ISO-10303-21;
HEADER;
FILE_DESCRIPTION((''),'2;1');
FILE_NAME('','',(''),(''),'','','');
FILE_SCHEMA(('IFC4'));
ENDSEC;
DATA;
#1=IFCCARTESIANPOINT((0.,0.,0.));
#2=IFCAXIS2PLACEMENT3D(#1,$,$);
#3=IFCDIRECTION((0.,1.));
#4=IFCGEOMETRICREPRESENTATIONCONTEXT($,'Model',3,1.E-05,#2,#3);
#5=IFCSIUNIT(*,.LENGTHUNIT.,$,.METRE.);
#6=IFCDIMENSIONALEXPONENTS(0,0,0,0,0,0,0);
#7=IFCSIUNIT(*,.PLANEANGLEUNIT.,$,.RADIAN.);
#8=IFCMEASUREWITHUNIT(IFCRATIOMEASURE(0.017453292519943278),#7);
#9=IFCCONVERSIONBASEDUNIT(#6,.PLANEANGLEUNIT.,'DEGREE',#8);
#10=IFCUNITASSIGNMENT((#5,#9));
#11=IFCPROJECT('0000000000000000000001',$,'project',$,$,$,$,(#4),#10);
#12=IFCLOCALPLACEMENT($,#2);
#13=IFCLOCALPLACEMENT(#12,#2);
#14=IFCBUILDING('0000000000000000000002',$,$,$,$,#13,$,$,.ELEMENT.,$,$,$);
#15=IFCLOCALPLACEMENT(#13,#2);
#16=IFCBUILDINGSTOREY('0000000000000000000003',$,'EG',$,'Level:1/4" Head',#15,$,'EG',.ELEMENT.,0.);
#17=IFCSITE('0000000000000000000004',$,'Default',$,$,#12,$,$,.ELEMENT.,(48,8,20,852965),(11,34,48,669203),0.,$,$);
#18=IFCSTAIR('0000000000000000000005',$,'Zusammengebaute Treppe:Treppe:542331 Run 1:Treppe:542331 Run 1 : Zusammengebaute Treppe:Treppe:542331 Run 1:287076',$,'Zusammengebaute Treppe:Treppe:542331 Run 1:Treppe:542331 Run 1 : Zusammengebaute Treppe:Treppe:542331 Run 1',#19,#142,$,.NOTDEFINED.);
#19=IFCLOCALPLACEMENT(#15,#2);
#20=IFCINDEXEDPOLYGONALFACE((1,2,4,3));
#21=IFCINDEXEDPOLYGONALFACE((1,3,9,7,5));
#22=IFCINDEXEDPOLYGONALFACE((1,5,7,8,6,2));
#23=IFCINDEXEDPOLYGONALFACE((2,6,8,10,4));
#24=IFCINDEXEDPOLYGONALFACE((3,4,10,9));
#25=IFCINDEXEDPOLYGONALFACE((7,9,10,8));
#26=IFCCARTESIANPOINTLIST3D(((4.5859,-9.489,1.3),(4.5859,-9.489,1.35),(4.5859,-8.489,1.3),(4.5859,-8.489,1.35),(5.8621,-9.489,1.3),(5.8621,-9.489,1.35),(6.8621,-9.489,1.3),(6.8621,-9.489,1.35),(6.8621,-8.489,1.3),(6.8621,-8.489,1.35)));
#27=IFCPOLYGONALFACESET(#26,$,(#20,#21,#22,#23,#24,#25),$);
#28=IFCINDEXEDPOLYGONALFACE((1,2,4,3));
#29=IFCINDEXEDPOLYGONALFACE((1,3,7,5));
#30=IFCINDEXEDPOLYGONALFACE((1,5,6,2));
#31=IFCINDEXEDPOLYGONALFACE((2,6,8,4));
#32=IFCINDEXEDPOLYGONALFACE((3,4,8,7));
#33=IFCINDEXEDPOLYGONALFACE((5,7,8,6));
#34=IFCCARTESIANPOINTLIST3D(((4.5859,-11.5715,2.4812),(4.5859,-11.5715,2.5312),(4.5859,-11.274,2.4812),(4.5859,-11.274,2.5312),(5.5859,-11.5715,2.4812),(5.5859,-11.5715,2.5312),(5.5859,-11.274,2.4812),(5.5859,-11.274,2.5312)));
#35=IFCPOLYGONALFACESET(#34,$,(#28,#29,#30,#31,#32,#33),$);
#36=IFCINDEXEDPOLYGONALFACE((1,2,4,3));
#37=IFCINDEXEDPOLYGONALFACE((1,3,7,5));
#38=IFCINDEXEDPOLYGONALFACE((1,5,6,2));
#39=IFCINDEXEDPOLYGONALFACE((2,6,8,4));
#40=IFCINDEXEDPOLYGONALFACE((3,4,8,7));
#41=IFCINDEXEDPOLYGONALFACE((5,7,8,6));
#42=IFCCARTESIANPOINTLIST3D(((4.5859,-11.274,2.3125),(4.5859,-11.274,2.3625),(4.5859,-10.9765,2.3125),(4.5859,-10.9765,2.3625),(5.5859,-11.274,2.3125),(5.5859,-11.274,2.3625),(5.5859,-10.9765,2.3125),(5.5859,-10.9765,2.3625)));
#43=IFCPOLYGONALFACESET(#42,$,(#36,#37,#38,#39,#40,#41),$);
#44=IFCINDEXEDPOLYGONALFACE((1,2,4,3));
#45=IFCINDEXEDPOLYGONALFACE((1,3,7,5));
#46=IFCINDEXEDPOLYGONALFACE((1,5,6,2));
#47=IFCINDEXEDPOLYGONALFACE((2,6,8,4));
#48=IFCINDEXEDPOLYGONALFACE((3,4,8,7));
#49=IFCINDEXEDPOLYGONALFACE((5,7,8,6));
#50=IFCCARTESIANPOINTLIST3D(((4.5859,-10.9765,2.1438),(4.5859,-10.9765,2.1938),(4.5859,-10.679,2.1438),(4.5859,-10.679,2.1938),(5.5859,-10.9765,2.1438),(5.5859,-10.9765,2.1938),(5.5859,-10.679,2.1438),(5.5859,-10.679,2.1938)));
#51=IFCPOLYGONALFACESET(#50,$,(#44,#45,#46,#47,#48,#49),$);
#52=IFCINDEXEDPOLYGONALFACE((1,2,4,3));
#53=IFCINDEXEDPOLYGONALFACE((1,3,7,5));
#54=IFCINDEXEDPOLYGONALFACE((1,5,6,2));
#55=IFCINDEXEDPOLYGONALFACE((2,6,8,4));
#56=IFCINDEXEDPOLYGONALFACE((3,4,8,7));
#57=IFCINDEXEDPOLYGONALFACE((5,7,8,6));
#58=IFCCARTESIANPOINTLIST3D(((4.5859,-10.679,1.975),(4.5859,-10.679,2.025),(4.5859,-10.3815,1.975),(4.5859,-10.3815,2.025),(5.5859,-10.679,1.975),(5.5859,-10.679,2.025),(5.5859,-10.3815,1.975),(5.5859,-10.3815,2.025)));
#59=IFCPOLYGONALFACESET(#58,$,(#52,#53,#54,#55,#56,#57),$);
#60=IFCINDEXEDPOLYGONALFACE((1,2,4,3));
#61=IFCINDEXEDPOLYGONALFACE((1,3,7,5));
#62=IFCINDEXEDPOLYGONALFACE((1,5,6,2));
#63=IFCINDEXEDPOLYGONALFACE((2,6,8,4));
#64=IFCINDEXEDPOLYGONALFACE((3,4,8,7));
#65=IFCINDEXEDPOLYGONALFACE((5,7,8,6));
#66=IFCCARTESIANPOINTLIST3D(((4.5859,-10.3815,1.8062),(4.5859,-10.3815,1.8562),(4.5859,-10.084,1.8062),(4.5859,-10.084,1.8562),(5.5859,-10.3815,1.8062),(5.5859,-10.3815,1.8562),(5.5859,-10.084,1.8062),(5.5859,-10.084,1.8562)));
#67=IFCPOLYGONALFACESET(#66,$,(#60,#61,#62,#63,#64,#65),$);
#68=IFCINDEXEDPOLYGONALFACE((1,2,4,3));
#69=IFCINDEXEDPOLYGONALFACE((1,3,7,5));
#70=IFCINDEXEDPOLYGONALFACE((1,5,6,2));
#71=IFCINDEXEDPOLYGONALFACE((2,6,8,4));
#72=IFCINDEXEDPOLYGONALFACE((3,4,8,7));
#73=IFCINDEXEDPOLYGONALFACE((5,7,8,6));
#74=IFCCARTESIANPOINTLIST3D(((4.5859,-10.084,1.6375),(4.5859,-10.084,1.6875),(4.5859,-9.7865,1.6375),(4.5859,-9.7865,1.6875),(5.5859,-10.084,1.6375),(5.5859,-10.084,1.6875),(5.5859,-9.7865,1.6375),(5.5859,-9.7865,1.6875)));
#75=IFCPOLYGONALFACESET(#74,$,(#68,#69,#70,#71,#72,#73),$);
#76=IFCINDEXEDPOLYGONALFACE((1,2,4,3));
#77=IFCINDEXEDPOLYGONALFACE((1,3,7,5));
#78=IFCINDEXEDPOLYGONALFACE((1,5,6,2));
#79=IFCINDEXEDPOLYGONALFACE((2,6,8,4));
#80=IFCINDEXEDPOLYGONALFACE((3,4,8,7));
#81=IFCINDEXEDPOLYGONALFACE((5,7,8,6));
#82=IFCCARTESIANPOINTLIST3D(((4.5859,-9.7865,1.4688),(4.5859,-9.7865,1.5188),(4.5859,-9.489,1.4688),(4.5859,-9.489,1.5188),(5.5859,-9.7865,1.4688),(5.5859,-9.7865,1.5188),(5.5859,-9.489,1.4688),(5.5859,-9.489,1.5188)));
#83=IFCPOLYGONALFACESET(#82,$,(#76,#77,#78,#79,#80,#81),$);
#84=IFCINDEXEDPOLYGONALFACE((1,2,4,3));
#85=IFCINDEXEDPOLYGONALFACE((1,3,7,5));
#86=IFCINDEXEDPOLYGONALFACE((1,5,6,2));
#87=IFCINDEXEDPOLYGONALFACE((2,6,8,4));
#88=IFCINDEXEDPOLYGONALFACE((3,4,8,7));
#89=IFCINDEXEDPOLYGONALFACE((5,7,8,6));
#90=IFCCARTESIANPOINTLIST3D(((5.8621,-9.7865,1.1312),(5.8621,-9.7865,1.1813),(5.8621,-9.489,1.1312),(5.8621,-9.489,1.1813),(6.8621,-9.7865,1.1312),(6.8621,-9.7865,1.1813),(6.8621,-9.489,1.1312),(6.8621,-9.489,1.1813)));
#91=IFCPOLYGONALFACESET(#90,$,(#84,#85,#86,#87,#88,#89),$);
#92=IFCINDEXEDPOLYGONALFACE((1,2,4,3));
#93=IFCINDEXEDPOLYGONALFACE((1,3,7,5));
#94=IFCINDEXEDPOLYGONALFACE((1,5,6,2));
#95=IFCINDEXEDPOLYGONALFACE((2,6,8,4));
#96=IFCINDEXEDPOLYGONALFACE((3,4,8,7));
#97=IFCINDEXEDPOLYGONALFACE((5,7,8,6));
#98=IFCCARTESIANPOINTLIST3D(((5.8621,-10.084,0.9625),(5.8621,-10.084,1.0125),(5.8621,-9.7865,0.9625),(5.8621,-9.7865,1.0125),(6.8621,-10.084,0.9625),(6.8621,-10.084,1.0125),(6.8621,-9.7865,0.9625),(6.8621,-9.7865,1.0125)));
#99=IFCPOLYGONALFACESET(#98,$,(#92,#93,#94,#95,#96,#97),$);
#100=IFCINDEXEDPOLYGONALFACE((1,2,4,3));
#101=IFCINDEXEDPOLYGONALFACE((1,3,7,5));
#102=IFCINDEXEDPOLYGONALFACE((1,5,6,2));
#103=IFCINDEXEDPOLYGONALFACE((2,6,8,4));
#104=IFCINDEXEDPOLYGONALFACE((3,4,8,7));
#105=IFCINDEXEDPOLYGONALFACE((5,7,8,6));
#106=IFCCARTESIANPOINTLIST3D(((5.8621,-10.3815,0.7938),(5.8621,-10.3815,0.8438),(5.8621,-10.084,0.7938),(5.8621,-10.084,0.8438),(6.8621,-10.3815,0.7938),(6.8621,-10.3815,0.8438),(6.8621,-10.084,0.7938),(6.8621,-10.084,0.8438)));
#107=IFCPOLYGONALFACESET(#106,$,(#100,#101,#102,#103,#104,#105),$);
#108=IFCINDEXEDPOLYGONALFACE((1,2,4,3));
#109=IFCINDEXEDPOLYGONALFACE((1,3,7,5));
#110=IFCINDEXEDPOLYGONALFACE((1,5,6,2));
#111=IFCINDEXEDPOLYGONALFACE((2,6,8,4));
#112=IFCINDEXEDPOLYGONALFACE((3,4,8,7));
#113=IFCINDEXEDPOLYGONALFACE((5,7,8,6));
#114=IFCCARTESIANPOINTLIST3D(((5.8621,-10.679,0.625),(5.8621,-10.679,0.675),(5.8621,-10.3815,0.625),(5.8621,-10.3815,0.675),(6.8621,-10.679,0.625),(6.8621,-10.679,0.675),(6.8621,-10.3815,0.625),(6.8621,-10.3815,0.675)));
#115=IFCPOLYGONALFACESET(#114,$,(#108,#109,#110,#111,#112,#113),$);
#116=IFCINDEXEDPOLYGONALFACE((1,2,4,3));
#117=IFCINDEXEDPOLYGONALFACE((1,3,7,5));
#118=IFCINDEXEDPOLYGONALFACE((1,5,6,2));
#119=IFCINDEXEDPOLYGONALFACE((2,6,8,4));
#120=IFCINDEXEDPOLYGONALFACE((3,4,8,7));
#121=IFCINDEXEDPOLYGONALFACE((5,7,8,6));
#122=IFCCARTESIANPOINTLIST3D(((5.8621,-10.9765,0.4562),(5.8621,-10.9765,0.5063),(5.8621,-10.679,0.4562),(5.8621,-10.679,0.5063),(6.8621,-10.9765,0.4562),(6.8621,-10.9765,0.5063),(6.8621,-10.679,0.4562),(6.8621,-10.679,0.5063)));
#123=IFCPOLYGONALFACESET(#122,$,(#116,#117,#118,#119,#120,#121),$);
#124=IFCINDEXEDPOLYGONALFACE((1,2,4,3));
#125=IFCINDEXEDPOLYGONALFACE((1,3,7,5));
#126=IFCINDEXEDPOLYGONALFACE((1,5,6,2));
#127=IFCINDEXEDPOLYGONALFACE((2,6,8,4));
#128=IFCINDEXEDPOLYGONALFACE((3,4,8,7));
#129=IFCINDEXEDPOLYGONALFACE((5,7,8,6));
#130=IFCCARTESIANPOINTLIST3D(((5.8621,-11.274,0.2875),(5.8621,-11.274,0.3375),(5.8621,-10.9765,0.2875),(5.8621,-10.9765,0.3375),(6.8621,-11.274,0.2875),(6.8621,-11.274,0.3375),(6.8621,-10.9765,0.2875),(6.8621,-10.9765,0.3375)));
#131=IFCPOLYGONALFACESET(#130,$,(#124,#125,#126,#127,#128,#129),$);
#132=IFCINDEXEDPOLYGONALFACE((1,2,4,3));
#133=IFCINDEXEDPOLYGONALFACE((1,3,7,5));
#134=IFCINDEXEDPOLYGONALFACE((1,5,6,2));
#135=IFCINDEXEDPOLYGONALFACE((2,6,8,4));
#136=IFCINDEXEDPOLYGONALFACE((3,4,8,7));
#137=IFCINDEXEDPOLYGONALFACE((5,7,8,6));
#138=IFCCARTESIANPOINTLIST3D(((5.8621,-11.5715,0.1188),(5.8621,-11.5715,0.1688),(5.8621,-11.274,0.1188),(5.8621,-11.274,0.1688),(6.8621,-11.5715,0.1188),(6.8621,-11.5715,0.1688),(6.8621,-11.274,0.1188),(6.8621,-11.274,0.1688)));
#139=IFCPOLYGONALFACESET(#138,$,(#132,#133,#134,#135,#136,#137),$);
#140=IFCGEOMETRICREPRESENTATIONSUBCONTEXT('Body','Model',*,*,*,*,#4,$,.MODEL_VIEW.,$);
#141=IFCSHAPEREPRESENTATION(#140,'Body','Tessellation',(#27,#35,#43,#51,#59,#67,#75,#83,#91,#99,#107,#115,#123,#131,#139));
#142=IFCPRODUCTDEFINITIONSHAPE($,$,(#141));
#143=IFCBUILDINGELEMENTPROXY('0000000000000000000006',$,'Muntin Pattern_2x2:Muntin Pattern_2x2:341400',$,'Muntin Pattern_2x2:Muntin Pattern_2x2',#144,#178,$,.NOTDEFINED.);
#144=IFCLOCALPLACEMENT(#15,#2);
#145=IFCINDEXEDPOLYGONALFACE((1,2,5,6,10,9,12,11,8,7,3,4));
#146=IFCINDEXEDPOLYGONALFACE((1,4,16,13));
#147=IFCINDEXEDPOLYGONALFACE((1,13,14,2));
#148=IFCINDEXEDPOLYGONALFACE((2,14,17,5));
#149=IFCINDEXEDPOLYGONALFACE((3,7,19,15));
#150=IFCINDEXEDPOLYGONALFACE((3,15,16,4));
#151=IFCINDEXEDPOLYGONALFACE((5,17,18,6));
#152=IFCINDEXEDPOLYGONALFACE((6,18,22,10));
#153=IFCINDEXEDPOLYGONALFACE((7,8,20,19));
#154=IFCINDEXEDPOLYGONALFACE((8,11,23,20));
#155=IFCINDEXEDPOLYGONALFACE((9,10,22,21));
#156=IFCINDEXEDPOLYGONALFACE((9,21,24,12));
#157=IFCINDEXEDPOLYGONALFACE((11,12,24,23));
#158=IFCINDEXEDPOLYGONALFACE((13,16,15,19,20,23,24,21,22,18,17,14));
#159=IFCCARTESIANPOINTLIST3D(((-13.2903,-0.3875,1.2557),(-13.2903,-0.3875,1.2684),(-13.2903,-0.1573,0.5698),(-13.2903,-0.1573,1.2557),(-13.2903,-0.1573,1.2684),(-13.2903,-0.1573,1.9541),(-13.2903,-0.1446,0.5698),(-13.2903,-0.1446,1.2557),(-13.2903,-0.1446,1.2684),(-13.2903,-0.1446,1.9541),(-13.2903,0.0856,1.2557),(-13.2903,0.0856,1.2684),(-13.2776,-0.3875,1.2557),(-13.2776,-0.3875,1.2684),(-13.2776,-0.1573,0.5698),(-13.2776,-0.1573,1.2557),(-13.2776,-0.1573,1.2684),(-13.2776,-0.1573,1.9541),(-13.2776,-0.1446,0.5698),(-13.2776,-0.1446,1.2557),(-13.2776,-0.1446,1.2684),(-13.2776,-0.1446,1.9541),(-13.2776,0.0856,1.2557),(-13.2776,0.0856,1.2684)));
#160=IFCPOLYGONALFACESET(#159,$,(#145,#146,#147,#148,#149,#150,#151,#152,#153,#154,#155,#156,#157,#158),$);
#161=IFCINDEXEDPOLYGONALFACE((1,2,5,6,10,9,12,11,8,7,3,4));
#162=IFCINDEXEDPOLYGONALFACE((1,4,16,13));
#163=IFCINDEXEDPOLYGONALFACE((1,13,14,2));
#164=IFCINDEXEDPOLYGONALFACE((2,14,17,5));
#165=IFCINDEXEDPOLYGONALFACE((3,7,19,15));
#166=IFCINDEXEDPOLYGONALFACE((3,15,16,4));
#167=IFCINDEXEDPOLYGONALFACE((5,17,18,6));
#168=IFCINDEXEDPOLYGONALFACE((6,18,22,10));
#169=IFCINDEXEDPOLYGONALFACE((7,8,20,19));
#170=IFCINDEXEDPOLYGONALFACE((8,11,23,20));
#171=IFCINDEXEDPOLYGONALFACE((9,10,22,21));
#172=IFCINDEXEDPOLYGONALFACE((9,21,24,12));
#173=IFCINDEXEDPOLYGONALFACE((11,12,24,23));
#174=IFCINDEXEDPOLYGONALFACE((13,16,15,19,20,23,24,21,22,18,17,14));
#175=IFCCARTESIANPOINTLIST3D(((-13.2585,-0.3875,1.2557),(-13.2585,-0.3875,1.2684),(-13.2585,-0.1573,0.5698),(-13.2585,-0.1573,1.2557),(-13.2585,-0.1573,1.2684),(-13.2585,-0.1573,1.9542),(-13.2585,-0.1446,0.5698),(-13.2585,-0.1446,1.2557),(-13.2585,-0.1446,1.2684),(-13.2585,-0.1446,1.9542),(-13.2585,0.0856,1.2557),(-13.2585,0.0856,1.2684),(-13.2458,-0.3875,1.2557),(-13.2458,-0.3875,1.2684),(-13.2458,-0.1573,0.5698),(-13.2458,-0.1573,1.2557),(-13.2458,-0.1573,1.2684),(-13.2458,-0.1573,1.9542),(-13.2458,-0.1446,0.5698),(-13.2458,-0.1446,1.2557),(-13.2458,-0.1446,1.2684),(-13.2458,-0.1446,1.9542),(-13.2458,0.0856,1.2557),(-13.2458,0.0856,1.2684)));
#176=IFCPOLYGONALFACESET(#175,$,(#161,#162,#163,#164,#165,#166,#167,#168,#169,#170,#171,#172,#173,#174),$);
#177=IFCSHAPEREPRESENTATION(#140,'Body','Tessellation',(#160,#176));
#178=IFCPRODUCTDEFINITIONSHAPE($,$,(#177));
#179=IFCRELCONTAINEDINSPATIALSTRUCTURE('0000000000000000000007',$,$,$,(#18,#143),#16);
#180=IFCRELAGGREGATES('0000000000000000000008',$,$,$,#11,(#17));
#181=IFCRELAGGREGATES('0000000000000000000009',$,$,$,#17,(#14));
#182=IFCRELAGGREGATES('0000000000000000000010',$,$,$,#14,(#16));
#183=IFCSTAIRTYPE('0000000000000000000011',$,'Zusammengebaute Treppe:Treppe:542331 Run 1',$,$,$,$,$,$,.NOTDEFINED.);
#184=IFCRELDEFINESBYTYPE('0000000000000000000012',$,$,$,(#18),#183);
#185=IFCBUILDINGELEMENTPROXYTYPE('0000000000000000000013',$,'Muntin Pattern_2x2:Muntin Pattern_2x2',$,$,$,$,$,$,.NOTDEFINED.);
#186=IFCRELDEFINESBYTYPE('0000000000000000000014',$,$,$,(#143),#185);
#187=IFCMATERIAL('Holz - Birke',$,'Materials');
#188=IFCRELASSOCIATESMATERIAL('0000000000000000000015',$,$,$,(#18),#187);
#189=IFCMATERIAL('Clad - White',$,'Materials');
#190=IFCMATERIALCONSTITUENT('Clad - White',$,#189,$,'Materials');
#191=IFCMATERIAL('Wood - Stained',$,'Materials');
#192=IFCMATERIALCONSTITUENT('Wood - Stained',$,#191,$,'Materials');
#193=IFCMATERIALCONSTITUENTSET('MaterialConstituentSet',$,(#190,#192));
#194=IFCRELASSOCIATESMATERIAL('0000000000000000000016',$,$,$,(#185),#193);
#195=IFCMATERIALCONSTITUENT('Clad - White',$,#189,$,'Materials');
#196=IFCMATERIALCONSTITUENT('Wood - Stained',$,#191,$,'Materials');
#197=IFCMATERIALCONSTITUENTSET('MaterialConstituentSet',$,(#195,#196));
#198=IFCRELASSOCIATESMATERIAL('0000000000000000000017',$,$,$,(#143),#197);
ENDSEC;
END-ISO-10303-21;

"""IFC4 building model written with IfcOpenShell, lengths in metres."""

from ifc_helpers import new_model, entity, si_unit, converted_unit, direction, frame, origin, place, context, subcontext, project, spatial, indexed_curve, outline, extrude, source, transform, mapped, material, constituent, constituent_set, type_object, type_shapes, element, save


model = new_model("IFC4")

# Units and contexts
model_context = context("Model", 3, precision=1e-05, world=origin(), true_north=direction((0.0, 1.0)))
body_context = subcontext(model_context, "Body", "Model", "MODEL_VIEW")
ifc_project = project(units=[si_unit("LENGTHUNIT", "METRE"), converted_unit("PLANEANGLEUNIT", "DEGREE", entity("IfcRatioMeasure", 0.017453292519943278), si_unit("PLANEANGLEUNIT", "RADIAN"), dimensions=[0, 0, 0, 0, 0, 0, 0])], contexts=[model_context])

# Site, building, storey
site_placement = place(None, origin())
site = spatial("IfcSite", under=ifc_project, at=site_placement, Name="Default", CompositionType="ELEMENT", RefLatitude=(48, 8, 20, 852965), RefLongitude=(11, 34, 48, 669203), RefElevation=0.0)
building_placement = place(site_placement, origin())
building = spatial("IfcBuilding", under=site, at=building_placement, CompositionType="ELEMENT")
storey_placement = place(building_placement, origin())
storey = spatial("IfcBuildingStorey", under=building, at=storey_placement, Name="EG", ObjectType="Level:1/4\" Head", LongName="EG", CompositionType="ELEMENT", Elevation=0.0)

# Stair
ifc_material_1 = material(Name="Holz - Birke", Category="Materials")
stair_type_1 = type_object("IfcStairType", Name="Zusammengebaute Treppe:Treppe:542331 Run 1", PredefinedType="NOTDEFINED")
stair_1_placement = place(storey_placement, origin())
element("IfcStair", 1, at=stair_1_placement, inside=storey, type_object=stair_type_1, material=ifc_material_1, Name="Zusammengebaute Treppe:Treppe:542331 Run 1:Treppe:542331 Run 1 : Zusammengebaute Treppe:Treppe:542331 Run 1:287076", ObjectType="Zusammengebaute Treppe:Treppe:542331 Run 1:Treppe:542331 Run 1 : Zusammengebaute Treppe:Treppe:542331 Run 1", PredefinedType="NOTDEFINED", context=body_context, shape_type="SweptSolid", body=[
    extrude(outline(indexed_curve([(-0.4, -1.1105), (0.6, -1.1105), (0.6, 1.1657), (-0.4, 1.1657), (-0.4, -0.1105), (-0.4, -1.1105)], self_intersect=False)), frame((5.7516, -9.089, 1.3), z_axis=(0.0, 0.0, 1.0), x_axis=(0.0, 1.0, 0.0)), (0.0, 0.0, 1.0), 0.05),
    extrude(outline(indexed_curve([(-0.5, -0.1487), (0.5, -0.1487), (0.5, 0.1487), (-0.5, 0.1487), (-0.5, -0.1487)], self_intersect=False)), frame((5.0859, -11.4228, 2.4813), z_axis=(0.0, 0.0, 1.0), x_axis=(-1.0, 0.0, 0.0)), (0.0, 0.0, 1.0), 0.05),
    extrude(outline(indexed_curve([(-0.5, -0.1487), (0.5, -0.1487), (0.5, 0.1487), (-0.5, 0.1487), (-0.5, -0.1487)], self_intersect=False)), frame((5.0859, -11.1253, 2.3125), z_axis=(0.0, 0.0, 1.0), x_axis=(-1.0, 0.0, 0.0)), (0.0, 0.0, 1.0), 0.05),
    extrude(outline(indexed_curve([(-0.5, -0.1487), (0.5, -0.1487), (0.5, 0.1487), (-0.5, 0.1487), (-0.5, -0.1487)], self_intersect=False)), frame((5.0859, -10.8278, 2.1438), z_axis=(0.0, 0.0, 1.0), x_axis=(-1.0, 0.0, 0.0)), (0.0, 0.0, 1.0), 0.05),
    extrude(outline(indexed_curve([(-0.5, -0.1487), (0.5, -0.1487), (0.5, 0.1487), (-0.5, 0.1487), (-0.5, -0.1487)], self_intersect=False)), frame((5.0859, -10.5303, 1.975), z_axis=(0.0, 0.0, 1.0), x_axis=(-1.0, 0.0, 0.0)), (0.0, 0.0, 1.0), 0.05),
    extrude(outline(indexed_curve([(-0.5, -0.1487), (0.5, -0.1487), (0.5, 0.1487), (-0.5, 0.1487), (-0.5, -0.1487)], self_intersect=False)), frame((5.0859, -10.2328, 1.8063), z_axis=(0.0, 0.0, 1.0), x_axis=(-1.0, 0.0, 0.0)), (0.0, 0.0, 1.0), 0.05),
    extrude(outline(indexed_curve([(-0.5, -0.1487), (0.5, -0.1487), (0.5, 0.1488), (-0.5, 0.1488), (-0.5, -0.1487)], self_intersect=False)), frame((5.0859, -9.9353, 1.6375), z_axis=(0.0, 0.0, 1.0), x_axis=(-1.0, 0.0, 0.0)), (0.0, 0.0, 1.0), 0.05),
    extrude(outline(indexed_curve([(-0.5, -0.1487), (0.5, -0.1487), (0.5, 0.1487), (-0.5, 0.1487), (-0.5, -0.1487)], self_intersect=False)), frame((5.0859, -9.6378, 1.4688), z_axis=(0.0, 0.0, 1.0), x_axis=(-1.0, 0.0, 0.0)), (0.0, 0.0, 1.0), 0.05),
    extrude(outline(indexed_curve([(-0.5, -0.1487), (0.5, -0.1487), (0.5, 0.1487), (-0.5, 0.1487), (-0.5, -0.1487)], self_intersect=False)), frame((6.3621, -9.6378, 1.1313)), (0.0, 0.0, 1.0), 0.05),
    extrude(outline(indexed_curve([(-0.5, -0.1487), (0.5, -0.1487), (0.5, 0.1487), (-0.5, 0.1487), (-0.5, -0.1487)], self_intersect=False)), frame((6.3621, -9.9353, 0.9625)), (0.0, 0.0, 1.0), 0.05),
    extrude(outline(indexed_curve([(-0.5, -0.1487), (0.5, -0.1487), (0.5, 0.1487), (-0.5, 0.1487), (-0.5, -0.1487)], self_intersect=False)), frame((6.3621, -10.2328, 0.7938)), (0.0, 0.0, 1.0), 0.05),
    extrude(outline(indexed_curve([(-0.5, -0.1487), (0.5, -0.1487), (0.5, 0.1487), (-0.5, 0.1487), (-0.5, -0.1487)], self_intersect=False)), frame((6.3621, -10.5303, 0.625)), (0.0, 0.0, 1.0), 0.05),
    extrude(outline(indexed_curve([(-0.5, -0.1487), (0.5, -0.1487), (0.5, 0.1487), (-0.5, 0.1487), (-0.5, -0.1487)], self_intersect=False)), frame((6.3621, -10.8278, 0.4563)), (0.0, 0.0, 1.0), 0.05),
    extrude(outline(indexed_curve([(-0.5, -0.1487), (0.5, -0.1487), (0.5, 0.1488), (-0.5, 0.1488), (-0.5, -0.1487)], self_intersect=False)), frame((6.3621, -11.1253, 0.2875)), (0.0, 0.0, 1.0), 0.05),
    extrude(outline(indexed_curve([(-0.5, -0.1487), (0.5, -0.1487), (0.5, 0.1488), (-0.5, 0.1488), (-0.5, -0.1487)], self_intersect=False)), frame((6.3621, -11.4228, 0.1188)), (0.0, 0.0, 1.0), 0.05),
])

# Building element proxy
ifc_material_2 = material(Name="Clad - White", Category="Materials")
ifc_constituent_1 = constituent(ifc_material_2, Name="Clad - White", Category="Materials")
ifc_material_3 = material(Name="Wood - Stained", Category="Materials")
ifc_constituent_2 = constituent(ifc_material_3, Name="Wood - Stained", Category="Materials")
ifc_constituent_set_1 = constituent_set(constituents=[ifc_constituent_1, ifc_constituent_2], Name="MaterialConstituentSet")
ifc_constituent_3 = constituent(ifc_material_2, Name="Clad - White", Category="Materials")
ifc_constituent_4 = constituent(ifc_material_3, Name="Wood - Stained", Category="Materials")
ifc_constituent_set_2 = constituent_set(constituents=[ifc_constituent_3, ifc_constituent_4], Name="MaterialConstituentSet")
building_element_proxy_type_1 = type_object("IfcBuildingElementProxyType", Name="Muntin Pattern_2x2:Muntin Pattern_2x2", PredefinedType="NOTDEFINED", material=ifc_constituent_set_2)
shared_shape_1 = source(origin(), body_context, "Body", "SweptSolid", [
    extrude(outline(indexed_curve([(0.0064, -0.0064), (0.6921, -0.0064), (0.6921, 0.0063), (0.0064, 0.0063), (0.0064, 0.2365), (-0.0063, 0.2365), (-0.0063, 0.0063), (-0.6922, 0.0063), (-0.6922, -0.0064), (-0.0063, -0.0064), (-0.0063, -0.2365), (0.0064, -0.2365), (0.0064, -0.0064)], self_intersect=False)), frame((0.0, -0.0222, 0.6921), z_axis=(0.0, 1.0, 0.0), x_axis=(0.0, 0.0, 1.0)), (0.0, 0.0, 1.0), 0.0127),
    extrude(outline(indexed_curve([(0.0064, -0.0064), (0.6922, -0.0064), (0.6922, 0.0063), (0.0064, 0.0063), (0.0064, 0.2365), (-0.0063, 0.2365), (-0.0063, 0.0063), (-0.6922, 0.0063), (-0.6922, -0.0064), (-0.0063, -0.0064), (-0.0063, -0.2365), (0.0064, -0.2365), (0.0064, -0.0064)], self_intersect=False)), frame((0.0, 0.0095, 0.6922), z_axis=(0.0, 1.0, 0.0), x_axis=(0.0, 0.0, 1.0)), (0.0, 0.0, 1.0), 0.0127),
])
type_shapes(building_element_proxy_type_1, [shared_shape_1])
proxy_1_placement = place(storey_placement, frame((-13.2681, -0.151, 0.5699), z_axis=(0.0, 0.0, 1.0), x_axis=(0.0, -1.0, 0.0)))
element("IfcBuildingElementProxy", 2, at=proxy_1_placement, inside=storey, type_object=building_element_proxy_type_1, material=ifc_constituent_set_1, Name="Muntin Pattern_2x2:Muntin Pattern_2x2:341400", ObjectType="Muntin Pattern_2x2:Muntin Pattern_2x2", PredefinedType="NOTDEFINED", context=body_context, shape_type="MappedRepresentation", body=[
    mapped(shared_shape_1, transform((0.0, 0.0, 0.0), scale=1.0)),
])

save(model, "model.ifc")
